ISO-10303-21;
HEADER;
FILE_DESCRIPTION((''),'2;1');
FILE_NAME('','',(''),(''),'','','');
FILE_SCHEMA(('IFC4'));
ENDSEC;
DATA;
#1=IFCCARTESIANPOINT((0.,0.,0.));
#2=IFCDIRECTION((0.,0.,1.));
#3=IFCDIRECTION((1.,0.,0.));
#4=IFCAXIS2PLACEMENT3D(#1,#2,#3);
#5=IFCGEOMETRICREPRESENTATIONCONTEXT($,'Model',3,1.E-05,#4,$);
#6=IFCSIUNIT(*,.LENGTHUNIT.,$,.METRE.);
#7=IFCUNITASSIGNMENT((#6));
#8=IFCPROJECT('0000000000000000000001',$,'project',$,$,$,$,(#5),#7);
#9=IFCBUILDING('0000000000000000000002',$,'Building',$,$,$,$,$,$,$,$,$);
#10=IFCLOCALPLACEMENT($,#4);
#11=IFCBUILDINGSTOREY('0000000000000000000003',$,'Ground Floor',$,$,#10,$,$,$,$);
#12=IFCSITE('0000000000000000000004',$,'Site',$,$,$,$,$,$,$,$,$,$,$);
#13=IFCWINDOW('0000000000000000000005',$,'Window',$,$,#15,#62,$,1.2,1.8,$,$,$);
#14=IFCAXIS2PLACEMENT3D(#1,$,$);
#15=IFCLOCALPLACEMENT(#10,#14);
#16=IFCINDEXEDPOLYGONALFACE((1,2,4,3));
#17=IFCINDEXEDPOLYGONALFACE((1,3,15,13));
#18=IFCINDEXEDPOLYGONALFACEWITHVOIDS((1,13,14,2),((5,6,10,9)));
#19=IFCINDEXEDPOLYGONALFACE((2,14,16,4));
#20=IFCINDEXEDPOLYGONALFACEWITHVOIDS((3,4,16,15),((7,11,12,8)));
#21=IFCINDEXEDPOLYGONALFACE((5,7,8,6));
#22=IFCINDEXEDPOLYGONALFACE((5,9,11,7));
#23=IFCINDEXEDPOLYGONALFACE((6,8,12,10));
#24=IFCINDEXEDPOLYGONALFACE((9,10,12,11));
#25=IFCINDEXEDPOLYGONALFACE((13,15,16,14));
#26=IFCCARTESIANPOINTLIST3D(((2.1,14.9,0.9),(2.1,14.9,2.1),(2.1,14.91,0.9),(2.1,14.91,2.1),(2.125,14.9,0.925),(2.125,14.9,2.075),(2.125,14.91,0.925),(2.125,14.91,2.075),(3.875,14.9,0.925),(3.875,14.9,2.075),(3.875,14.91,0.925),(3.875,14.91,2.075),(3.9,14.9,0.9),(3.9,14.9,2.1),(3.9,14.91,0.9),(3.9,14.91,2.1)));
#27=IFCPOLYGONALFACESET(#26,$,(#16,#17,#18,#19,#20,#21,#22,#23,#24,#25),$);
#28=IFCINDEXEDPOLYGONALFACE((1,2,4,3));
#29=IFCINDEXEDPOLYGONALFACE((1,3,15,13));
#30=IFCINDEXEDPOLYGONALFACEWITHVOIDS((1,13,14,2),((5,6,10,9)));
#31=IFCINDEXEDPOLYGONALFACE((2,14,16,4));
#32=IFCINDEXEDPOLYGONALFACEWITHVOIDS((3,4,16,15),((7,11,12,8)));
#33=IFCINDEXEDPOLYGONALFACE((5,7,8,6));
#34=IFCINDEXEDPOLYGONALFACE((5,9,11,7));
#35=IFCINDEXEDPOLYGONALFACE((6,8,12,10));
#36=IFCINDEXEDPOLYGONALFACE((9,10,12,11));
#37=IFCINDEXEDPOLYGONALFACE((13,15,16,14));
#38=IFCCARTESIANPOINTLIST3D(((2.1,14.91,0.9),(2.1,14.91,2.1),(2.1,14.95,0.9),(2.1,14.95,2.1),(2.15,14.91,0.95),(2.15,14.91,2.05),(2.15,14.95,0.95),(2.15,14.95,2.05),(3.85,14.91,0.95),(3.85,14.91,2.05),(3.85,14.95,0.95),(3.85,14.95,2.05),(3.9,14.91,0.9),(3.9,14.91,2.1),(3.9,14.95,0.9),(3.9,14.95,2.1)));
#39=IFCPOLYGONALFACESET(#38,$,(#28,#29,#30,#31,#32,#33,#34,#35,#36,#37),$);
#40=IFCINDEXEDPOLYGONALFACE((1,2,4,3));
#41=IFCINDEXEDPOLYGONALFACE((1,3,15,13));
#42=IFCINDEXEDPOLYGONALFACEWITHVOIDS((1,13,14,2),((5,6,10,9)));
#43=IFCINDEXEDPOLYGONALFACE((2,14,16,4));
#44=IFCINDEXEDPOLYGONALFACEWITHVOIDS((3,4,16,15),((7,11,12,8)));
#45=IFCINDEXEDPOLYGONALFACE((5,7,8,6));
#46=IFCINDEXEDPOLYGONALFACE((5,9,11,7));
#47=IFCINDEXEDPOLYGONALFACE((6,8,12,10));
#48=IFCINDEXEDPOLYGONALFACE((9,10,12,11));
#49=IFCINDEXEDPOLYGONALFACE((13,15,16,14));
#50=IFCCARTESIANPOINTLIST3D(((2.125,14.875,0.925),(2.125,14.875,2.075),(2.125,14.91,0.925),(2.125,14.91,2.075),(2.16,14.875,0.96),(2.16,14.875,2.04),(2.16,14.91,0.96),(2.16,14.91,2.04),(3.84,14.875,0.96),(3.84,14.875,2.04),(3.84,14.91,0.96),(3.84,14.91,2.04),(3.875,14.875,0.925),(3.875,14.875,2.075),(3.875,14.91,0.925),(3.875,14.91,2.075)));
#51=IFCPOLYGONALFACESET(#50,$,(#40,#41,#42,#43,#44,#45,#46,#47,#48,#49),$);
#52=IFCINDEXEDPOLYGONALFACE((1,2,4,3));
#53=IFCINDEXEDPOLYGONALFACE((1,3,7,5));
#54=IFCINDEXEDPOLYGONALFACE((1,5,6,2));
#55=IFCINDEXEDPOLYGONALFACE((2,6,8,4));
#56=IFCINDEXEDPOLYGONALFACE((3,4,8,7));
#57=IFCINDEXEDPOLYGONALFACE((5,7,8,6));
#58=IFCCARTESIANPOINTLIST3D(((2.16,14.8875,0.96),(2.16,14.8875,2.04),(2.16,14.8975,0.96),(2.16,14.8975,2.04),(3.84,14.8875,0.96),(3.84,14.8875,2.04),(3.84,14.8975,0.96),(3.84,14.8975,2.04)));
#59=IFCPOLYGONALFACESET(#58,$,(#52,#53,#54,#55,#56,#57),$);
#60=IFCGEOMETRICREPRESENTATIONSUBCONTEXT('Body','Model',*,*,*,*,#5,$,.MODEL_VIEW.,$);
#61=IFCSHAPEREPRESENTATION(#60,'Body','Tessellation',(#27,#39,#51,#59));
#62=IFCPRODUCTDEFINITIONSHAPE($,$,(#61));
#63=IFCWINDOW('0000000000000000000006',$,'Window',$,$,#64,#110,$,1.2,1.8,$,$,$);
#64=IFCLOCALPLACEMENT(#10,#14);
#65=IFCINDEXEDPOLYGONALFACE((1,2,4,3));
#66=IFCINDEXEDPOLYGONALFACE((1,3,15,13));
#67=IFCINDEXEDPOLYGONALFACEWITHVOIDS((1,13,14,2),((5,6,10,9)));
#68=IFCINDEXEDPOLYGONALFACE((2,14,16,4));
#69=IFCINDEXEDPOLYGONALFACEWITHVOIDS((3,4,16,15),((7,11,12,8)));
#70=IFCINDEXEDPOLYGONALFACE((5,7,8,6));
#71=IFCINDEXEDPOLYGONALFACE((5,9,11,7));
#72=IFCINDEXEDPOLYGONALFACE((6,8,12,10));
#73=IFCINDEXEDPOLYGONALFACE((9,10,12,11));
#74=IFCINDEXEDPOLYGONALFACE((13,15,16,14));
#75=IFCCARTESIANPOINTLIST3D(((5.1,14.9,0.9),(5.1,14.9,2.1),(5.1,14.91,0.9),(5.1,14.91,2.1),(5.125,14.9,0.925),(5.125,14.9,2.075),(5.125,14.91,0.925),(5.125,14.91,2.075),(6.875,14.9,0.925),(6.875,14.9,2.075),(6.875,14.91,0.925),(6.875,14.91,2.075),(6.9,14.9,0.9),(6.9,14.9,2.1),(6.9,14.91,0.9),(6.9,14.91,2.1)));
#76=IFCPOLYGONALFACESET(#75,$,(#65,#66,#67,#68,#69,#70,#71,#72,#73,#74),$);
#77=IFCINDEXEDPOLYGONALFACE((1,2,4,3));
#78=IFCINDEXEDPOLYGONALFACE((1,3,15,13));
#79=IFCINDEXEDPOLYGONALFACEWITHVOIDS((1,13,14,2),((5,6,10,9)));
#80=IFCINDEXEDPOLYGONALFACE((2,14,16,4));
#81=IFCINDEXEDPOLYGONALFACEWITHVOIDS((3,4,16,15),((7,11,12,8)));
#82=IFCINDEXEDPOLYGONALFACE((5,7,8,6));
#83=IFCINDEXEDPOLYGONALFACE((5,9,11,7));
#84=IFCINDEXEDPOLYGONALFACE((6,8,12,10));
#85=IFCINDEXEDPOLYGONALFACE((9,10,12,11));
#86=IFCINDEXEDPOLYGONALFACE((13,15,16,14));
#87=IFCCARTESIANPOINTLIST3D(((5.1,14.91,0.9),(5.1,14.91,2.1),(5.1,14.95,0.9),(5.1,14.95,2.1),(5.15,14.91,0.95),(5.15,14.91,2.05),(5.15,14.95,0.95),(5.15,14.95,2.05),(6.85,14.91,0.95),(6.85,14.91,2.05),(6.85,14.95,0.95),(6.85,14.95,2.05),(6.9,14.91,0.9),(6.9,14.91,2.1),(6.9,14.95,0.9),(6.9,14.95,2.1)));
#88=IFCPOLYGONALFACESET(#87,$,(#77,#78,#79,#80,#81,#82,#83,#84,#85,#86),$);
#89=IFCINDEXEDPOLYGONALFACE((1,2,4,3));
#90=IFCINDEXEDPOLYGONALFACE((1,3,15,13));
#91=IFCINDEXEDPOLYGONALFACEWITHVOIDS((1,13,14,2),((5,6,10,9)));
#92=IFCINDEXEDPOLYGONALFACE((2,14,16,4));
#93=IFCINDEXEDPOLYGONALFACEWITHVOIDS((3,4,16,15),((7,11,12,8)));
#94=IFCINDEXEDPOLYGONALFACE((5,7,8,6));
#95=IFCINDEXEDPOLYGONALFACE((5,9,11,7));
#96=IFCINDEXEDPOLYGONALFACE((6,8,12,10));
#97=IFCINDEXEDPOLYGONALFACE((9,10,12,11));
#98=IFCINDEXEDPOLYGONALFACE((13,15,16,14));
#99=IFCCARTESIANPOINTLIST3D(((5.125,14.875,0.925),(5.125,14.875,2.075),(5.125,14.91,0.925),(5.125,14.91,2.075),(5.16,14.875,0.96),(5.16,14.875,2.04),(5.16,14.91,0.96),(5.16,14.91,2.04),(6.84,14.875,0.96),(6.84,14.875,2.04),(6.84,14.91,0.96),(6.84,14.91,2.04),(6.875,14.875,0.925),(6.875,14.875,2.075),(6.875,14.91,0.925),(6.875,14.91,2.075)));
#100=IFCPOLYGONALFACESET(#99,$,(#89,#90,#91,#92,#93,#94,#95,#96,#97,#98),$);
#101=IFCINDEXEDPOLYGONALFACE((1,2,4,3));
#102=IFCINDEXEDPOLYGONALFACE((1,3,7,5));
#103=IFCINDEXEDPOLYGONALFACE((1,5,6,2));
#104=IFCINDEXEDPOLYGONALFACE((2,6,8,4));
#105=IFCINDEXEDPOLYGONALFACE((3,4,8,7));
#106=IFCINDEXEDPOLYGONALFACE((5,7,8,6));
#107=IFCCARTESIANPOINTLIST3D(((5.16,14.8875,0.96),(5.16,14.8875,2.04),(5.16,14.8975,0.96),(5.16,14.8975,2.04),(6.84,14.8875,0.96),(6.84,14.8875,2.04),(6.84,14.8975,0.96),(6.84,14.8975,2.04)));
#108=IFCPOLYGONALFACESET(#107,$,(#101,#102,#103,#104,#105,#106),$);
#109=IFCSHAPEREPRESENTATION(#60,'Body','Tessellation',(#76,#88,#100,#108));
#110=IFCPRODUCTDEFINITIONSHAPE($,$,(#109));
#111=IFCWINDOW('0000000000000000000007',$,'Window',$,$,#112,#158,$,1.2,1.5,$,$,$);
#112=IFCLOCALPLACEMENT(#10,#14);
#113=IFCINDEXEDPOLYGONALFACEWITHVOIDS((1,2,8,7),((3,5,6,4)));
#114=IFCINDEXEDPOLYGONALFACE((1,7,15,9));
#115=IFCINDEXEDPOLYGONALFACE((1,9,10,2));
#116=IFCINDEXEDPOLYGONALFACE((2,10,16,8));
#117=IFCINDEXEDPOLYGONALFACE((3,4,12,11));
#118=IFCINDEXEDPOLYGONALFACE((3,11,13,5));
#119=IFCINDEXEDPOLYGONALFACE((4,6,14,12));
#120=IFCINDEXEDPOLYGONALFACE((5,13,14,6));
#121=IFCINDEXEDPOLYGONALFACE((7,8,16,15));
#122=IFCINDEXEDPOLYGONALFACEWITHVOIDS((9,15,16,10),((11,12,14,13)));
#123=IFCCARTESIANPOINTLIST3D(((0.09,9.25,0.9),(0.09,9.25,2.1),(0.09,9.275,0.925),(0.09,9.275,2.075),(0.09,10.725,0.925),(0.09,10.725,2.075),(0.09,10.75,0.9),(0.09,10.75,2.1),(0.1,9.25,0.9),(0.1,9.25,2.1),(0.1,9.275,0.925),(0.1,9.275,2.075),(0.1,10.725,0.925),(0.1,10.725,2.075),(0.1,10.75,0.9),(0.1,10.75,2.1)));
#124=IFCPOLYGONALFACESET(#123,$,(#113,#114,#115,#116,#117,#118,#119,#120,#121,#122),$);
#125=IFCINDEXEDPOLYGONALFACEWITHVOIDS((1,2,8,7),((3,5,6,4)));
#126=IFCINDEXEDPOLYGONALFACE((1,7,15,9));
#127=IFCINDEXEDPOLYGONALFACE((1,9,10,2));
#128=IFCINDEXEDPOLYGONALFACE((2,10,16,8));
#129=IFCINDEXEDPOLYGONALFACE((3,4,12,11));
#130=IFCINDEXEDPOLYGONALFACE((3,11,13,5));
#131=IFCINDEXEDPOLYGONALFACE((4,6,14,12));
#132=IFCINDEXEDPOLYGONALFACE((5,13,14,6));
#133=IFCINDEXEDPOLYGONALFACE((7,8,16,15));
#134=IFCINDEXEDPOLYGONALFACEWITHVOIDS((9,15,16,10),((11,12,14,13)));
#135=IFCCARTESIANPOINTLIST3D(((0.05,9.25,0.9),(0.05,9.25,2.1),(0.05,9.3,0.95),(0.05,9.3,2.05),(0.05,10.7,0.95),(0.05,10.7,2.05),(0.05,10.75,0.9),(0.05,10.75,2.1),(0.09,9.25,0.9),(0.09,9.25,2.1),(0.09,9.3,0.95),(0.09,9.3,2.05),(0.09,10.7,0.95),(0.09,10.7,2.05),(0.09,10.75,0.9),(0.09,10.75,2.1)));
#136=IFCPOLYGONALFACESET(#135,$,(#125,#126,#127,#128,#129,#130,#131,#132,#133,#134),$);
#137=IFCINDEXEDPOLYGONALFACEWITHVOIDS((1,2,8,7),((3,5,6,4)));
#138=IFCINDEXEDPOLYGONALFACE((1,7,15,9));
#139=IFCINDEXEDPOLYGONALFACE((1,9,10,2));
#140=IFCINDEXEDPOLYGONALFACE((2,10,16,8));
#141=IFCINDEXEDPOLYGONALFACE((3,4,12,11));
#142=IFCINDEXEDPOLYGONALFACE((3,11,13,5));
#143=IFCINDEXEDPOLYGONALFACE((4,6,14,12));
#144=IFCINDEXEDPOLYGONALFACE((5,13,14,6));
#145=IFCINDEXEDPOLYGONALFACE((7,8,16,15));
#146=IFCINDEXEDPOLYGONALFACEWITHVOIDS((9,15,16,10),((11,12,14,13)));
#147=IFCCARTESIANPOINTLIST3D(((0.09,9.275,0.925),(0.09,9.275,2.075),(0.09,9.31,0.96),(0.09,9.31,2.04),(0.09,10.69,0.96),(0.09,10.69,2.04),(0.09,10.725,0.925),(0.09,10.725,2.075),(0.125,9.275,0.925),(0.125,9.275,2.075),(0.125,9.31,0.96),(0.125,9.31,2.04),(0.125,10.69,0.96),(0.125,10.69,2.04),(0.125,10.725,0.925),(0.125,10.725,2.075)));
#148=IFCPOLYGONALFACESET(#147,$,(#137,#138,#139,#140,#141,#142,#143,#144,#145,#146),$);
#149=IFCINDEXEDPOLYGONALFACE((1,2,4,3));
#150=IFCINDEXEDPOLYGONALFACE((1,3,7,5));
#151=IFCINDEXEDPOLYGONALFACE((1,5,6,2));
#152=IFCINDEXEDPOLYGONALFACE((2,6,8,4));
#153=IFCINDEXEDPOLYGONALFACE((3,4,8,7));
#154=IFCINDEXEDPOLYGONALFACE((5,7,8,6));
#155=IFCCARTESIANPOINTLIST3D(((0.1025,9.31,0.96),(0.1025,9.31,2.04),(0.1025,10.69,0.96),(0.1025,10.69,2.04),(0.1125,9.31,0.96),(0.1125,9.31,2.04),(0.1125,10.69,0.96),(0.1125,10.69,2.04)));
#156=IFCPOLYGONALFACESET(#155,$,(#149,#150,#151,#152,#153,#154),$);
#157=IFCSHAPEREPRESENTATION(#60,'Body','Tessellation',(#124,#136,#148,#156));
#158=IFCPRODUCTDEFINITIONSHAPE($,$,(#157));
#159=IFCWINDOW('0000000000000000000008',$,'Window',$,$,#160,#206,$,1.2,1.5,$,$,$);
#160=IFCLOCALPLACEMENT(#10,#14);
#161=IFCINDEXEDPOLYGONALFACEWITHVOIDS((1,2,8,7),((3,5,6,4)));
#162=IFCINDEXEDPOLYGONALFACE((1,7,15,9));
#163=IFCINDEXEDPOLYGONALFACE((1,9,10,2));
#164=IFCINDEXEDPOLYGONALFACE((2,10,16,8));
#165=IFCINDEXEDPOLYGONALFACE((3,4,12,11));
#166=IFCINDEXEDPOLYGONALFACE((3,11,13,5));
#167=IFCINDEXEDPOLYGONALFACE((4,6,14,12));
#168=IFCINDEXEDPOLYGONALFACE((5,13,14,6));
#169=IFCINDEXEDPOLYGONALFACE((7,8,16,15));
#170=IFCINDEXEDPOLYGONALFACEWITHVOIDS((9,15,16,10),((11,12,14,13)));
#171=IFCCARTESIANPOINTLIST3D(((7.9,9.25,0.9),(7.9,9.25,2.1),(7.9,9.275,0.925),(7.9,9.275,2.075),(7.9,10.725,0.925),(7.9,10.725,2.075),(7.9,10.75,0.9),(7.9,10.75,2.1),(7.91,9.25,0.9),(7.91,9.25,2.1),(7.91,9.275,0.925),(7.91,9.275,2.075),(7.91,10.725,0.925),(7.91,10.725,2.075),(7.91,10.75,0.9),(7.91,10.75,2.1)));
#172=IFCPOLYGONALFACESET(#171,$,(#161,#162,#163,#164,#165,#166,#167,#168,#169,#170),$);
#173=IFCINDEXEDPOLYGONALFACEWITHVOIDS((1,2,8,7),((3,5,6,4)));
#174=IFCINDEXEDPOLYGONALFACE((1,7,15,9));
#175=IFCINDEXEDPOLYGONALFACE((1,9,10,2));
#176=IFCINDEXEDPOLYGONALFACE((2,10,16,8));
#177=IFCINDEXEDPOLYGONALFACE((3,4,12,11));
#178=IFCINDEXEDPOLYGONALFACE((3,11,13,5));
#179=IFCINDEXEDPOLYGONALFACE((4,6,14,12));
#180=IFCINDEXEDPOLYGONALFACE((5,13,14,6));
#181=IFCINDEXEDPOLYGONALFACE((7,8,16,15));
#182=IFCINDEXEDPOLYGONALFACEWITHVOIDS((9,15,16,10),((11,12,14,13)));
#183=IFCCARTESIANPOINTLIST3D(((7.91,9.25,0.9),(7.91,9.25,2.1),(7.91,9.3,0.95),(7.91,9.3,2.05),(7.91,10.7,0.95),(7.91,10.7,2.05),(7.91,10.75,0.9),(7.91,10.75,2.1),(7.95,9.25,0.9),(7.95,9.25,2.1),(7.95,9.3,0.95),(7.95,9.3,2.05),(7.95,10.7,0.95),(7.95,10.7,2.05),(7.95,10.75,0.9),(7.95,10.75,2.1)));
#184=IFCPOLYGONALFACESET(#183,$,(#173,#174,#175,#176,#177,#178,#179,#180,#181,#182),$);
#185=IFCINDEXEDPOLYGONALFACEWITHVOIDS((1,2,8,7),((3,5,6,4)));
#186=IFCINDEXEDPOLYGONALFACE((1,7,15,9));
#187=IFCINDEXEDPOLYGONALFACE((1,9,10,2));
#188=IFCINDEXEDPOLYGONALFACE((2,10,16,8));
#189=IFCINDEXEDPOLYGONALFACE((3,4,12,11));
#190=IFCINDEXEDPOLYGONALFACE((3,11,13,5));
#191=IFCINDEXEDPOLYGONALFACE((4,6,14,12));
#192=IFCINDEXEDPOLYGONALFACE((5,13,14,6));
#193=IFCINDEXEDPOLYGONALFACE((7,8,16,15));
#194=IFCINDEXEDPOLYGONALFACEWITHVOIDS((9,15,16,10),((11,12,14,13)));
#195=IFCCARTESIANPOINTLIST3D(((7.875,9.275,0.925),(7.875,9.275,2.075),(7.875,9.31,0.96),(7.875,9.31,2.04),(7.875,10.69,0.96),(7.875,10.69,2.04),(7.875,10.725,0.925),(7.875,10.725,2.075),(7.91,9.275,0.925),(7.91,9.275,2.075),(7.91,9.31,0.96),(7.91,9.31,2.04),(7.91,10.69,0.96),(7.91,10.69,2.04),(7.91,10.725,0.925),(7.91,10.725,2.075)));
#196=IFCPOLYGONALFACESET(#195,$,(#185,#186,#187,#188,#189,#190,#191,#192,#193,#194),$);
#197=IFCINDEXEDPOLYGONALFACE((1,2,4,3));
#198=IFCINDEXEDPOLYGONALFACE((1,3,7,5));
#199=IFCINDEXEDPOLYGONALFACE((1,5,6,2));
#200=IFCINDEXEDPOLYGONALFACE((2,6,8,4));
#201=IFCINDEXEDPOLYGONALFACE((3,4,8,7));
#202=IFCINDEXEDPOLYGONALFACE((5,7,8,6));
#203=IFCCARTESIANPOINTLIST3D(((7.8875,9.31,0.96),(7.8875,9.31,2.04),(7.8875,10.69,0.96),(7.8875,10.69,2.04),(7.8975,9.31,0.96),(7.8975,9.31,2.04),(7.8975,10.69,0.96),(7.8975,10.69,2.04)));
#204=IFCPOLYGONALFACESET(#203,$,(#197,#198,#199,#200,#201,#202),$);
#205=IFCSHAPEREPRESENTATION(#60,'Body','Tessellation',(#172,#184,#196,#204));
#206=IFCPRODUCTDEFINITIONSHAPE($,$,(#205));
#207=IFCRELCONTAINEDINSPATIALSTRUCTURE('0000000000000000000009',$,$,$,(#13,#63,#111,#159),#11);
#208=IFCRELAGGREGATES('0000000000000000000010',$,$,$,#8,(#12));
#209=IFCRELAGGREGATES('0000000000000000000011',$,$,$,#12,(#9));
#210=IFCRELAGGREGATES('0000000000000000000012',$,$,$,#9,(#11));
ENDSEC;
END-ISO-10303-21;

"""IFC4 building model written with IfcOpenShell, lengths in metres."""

from ifc_helpers import new_model, si_unit, frame, origin_with_axes, place, context, subcontext, project, spatial, line, indexed_curve, outline, extrude, element, save


model = new_model("IFC4")

# Units and contexts
model_context = context("Model", 3, precision=1e-05, world=origin_with_axes())
body_context = subcontext(model_context, "Body", "Model", "MODEL_VIEW")
ifc_project = project(units=[si_unit("LENGTHUNIT", "METRE")], contexts=[model_context])

# Site, building, storey
site = spatial("IfcSite", under=ifc_project, Name="Site")
building = spatial("IfcBuilding", under=site, Name="Building")
storey_placement = place(None, origin_with_axes())
storey = spatial("IfcBuildingStorey", under=building, at=storey_placement, Name="Ground Floor")

# Windows
for number, where, z_axis, x_axis, name in (
    (1, (3.9, 15.0, 0.9), (0.0, 0.0, 1.0), (-1.0, 0.0, 0.0), "Window"),
    (2, (6.9, 15.0, 0.9), (0.0, 0.0, 1.0), (-1.0, 0.0, 0.0), "Window"),
):
    element("IfcWindow", number, at=place(storey_placement, frame(where, z_axis=z_axis, x_axis=x_axis)), inside=storey, Name=name, OverallHeight=1.2, OverallWidth=1.8, context=body_context, shape_type="SweptSolid", body=[
        extrude(outline(indexed_curve([(0.0, 0.0), (1.8, 0.0), (1.8, 1.2), (0.0, 1.2)], segments=[line(1, 2, 3, 4, 1)]), holes=[indexed_curve([(0.025, 0.025), (1.775, 0.025), (1.775, 1.175), (0.025, 1.175)], segments=[line(1, 2, 3, 4, 1)])]), frame((0.0, 0.09, 0.0), z_axis=(0.0, -1.0, 0.0), x_axis=(1.0, 0.0, 0.0)), (0.0, 0.0, -1.0), 0.01),
        extrude(outline(indexed_curve([(0.0, 0.0), (1.8, 0.0), (1.8, 1.2), (0.0, 1.2)], segments=[line(1, 2, 3, 4, 1)]), holes=[indexed_curve([(0.05, 0.05), (1.75, 0.05), (1.75, 1.15), (0.05, 1.15)], segments=[line(1, 2, 3, 4, 1)])]), frame((0.0, 0.05, 0.0), z_axis=(0.0, -1.0, 0.0), x_axis=(1.0, 0.0, 0.0)), (0.0, 0.0, -1.0), 0.04),
        extrude(outline(indexed_curve([(0.0, 0.0), (1.75, 0.0), (1.75, 1.15), (0.0, 1.15)], segments=[line(1, 2, 3, 4, 1)]), holes=[indexed_curve([(0.035, 0.035), (1.715, 0.035), (1.715, 1.115), (0.035, 1.115)], segments=[line(1, 2, 3, 4, 1)])]), frame((0.025, 0.09, 0.025), z_axis=(0.0, -1.0, 0.0), x_axis=(1.0, 0.0, 0.0)), (0.0, 0.0, -1.0), 0.035),
        extrude(outline(indexed_curve([(0.035, 0.035), (1.715, 0.035), (1.715, 1.115), (0.035, 1.115)], segments=[line(1, 2, 3, 4, 1)])), frame((0.025, 0.1025, 0.025), z_axis=(0.0, -1.0, 0.0), x_axis=(1.0, 0.0, 0.0)), (0.0, 0.0, -1.0), 0.01),
    ])
for number, where, z_axis, x_axis, name in (
    (3, (0.0, 10.75, 0.9), (0.0, 0.0, 1.0), (0.0, -1.0, 0.0), "Window"),
    (4, (8.0, 9.25, 0.9), (0.0, 0.0, 1.0), (0.0, 1.0, 0.0), "Window"),
):
    element("IfcWindow", number, at=place(storey_placement, frame(where, z_axis=z_axis, x_axis=x_axis)), inside=storey, Name=name, OverallHeight=1.2, OverallWidth=1.5, context=body_context, shape_type="SweptSolid", body=[
        extrude(outline(indexed_curve([(0.0, 0.0), (1.5, 0.0), (1.5, 1.2), (0.0, 1.2)], segments=[line(1, 2, 3, 4, 1)]), holes=[indexed_curve([(0.025, 0.025), (1.475, 0.025), (1.475, 1.175), (0.025, 1.175)], segments=[line(1, 2, 3, 4, 1)])]), frame((0.0, 0.09, 0.0), z_axis=(0.0, -1.0, 0.0), x_axis=(1.0, 0.0, 0.0)), (0.0, 0.0, -1.0), 0.01),
        extrude(outline(indexed_curve([(0.0, 0.0), (1.5, 0.0), (1.5, 1.2), (0.0, 1.2)], segments=[line(1, 2, 3, 4, 1)]), holes=[indexed_curve([(0.05, 0.05), (1.45, 0.05), (1.45, 1.15), (0.05, 1.15)], segments=[line(1, 2, 3, 4, 1)])]), frame((0.0, 0.05, 0.0), z_axis=(0.0, -1.0, 0.0), x_axis=(1.0, 0.0, 0.0)), (0.0, 0.0, -1.0), 0.04),
        extrude(outline(indexed_curve([(0.0, 0.0), (1.45, 0.0), (1.45, 1.15), (0.0, 1.15)], segments=[line(1, 2, 3, 4, 1)]), holes=[indexed_curve([(0.035, 0.035), (1.415, 0.035), (1.415, 1.115), (0.035, 1.115)], segments=[line(1, 2, 3, 4, 1)])]), frame((0.025, 0.09, 0.025), z_axis=(0.0, -1.0, 0.0), x_axis=(1.0, 0.0, 0.0)), (0.0, 0.0, -1.0), 0.035),
        extrude(outline(indexed_curve([(0.035, 0.035), (1.415, 0.035), (1.415, 1.115), (0.035, 1.115)], segments=[line(1, 2, 3, 4, 1)])), frame((0.025, 0.1025, 0.025), z_axis=(0.0, -1.0, 0.0), x_axis=(1.0, 0.0, 0.0)), (0.0, 0.0, -1.0), 0.01),
    ])

save(model, "model.ifc")
